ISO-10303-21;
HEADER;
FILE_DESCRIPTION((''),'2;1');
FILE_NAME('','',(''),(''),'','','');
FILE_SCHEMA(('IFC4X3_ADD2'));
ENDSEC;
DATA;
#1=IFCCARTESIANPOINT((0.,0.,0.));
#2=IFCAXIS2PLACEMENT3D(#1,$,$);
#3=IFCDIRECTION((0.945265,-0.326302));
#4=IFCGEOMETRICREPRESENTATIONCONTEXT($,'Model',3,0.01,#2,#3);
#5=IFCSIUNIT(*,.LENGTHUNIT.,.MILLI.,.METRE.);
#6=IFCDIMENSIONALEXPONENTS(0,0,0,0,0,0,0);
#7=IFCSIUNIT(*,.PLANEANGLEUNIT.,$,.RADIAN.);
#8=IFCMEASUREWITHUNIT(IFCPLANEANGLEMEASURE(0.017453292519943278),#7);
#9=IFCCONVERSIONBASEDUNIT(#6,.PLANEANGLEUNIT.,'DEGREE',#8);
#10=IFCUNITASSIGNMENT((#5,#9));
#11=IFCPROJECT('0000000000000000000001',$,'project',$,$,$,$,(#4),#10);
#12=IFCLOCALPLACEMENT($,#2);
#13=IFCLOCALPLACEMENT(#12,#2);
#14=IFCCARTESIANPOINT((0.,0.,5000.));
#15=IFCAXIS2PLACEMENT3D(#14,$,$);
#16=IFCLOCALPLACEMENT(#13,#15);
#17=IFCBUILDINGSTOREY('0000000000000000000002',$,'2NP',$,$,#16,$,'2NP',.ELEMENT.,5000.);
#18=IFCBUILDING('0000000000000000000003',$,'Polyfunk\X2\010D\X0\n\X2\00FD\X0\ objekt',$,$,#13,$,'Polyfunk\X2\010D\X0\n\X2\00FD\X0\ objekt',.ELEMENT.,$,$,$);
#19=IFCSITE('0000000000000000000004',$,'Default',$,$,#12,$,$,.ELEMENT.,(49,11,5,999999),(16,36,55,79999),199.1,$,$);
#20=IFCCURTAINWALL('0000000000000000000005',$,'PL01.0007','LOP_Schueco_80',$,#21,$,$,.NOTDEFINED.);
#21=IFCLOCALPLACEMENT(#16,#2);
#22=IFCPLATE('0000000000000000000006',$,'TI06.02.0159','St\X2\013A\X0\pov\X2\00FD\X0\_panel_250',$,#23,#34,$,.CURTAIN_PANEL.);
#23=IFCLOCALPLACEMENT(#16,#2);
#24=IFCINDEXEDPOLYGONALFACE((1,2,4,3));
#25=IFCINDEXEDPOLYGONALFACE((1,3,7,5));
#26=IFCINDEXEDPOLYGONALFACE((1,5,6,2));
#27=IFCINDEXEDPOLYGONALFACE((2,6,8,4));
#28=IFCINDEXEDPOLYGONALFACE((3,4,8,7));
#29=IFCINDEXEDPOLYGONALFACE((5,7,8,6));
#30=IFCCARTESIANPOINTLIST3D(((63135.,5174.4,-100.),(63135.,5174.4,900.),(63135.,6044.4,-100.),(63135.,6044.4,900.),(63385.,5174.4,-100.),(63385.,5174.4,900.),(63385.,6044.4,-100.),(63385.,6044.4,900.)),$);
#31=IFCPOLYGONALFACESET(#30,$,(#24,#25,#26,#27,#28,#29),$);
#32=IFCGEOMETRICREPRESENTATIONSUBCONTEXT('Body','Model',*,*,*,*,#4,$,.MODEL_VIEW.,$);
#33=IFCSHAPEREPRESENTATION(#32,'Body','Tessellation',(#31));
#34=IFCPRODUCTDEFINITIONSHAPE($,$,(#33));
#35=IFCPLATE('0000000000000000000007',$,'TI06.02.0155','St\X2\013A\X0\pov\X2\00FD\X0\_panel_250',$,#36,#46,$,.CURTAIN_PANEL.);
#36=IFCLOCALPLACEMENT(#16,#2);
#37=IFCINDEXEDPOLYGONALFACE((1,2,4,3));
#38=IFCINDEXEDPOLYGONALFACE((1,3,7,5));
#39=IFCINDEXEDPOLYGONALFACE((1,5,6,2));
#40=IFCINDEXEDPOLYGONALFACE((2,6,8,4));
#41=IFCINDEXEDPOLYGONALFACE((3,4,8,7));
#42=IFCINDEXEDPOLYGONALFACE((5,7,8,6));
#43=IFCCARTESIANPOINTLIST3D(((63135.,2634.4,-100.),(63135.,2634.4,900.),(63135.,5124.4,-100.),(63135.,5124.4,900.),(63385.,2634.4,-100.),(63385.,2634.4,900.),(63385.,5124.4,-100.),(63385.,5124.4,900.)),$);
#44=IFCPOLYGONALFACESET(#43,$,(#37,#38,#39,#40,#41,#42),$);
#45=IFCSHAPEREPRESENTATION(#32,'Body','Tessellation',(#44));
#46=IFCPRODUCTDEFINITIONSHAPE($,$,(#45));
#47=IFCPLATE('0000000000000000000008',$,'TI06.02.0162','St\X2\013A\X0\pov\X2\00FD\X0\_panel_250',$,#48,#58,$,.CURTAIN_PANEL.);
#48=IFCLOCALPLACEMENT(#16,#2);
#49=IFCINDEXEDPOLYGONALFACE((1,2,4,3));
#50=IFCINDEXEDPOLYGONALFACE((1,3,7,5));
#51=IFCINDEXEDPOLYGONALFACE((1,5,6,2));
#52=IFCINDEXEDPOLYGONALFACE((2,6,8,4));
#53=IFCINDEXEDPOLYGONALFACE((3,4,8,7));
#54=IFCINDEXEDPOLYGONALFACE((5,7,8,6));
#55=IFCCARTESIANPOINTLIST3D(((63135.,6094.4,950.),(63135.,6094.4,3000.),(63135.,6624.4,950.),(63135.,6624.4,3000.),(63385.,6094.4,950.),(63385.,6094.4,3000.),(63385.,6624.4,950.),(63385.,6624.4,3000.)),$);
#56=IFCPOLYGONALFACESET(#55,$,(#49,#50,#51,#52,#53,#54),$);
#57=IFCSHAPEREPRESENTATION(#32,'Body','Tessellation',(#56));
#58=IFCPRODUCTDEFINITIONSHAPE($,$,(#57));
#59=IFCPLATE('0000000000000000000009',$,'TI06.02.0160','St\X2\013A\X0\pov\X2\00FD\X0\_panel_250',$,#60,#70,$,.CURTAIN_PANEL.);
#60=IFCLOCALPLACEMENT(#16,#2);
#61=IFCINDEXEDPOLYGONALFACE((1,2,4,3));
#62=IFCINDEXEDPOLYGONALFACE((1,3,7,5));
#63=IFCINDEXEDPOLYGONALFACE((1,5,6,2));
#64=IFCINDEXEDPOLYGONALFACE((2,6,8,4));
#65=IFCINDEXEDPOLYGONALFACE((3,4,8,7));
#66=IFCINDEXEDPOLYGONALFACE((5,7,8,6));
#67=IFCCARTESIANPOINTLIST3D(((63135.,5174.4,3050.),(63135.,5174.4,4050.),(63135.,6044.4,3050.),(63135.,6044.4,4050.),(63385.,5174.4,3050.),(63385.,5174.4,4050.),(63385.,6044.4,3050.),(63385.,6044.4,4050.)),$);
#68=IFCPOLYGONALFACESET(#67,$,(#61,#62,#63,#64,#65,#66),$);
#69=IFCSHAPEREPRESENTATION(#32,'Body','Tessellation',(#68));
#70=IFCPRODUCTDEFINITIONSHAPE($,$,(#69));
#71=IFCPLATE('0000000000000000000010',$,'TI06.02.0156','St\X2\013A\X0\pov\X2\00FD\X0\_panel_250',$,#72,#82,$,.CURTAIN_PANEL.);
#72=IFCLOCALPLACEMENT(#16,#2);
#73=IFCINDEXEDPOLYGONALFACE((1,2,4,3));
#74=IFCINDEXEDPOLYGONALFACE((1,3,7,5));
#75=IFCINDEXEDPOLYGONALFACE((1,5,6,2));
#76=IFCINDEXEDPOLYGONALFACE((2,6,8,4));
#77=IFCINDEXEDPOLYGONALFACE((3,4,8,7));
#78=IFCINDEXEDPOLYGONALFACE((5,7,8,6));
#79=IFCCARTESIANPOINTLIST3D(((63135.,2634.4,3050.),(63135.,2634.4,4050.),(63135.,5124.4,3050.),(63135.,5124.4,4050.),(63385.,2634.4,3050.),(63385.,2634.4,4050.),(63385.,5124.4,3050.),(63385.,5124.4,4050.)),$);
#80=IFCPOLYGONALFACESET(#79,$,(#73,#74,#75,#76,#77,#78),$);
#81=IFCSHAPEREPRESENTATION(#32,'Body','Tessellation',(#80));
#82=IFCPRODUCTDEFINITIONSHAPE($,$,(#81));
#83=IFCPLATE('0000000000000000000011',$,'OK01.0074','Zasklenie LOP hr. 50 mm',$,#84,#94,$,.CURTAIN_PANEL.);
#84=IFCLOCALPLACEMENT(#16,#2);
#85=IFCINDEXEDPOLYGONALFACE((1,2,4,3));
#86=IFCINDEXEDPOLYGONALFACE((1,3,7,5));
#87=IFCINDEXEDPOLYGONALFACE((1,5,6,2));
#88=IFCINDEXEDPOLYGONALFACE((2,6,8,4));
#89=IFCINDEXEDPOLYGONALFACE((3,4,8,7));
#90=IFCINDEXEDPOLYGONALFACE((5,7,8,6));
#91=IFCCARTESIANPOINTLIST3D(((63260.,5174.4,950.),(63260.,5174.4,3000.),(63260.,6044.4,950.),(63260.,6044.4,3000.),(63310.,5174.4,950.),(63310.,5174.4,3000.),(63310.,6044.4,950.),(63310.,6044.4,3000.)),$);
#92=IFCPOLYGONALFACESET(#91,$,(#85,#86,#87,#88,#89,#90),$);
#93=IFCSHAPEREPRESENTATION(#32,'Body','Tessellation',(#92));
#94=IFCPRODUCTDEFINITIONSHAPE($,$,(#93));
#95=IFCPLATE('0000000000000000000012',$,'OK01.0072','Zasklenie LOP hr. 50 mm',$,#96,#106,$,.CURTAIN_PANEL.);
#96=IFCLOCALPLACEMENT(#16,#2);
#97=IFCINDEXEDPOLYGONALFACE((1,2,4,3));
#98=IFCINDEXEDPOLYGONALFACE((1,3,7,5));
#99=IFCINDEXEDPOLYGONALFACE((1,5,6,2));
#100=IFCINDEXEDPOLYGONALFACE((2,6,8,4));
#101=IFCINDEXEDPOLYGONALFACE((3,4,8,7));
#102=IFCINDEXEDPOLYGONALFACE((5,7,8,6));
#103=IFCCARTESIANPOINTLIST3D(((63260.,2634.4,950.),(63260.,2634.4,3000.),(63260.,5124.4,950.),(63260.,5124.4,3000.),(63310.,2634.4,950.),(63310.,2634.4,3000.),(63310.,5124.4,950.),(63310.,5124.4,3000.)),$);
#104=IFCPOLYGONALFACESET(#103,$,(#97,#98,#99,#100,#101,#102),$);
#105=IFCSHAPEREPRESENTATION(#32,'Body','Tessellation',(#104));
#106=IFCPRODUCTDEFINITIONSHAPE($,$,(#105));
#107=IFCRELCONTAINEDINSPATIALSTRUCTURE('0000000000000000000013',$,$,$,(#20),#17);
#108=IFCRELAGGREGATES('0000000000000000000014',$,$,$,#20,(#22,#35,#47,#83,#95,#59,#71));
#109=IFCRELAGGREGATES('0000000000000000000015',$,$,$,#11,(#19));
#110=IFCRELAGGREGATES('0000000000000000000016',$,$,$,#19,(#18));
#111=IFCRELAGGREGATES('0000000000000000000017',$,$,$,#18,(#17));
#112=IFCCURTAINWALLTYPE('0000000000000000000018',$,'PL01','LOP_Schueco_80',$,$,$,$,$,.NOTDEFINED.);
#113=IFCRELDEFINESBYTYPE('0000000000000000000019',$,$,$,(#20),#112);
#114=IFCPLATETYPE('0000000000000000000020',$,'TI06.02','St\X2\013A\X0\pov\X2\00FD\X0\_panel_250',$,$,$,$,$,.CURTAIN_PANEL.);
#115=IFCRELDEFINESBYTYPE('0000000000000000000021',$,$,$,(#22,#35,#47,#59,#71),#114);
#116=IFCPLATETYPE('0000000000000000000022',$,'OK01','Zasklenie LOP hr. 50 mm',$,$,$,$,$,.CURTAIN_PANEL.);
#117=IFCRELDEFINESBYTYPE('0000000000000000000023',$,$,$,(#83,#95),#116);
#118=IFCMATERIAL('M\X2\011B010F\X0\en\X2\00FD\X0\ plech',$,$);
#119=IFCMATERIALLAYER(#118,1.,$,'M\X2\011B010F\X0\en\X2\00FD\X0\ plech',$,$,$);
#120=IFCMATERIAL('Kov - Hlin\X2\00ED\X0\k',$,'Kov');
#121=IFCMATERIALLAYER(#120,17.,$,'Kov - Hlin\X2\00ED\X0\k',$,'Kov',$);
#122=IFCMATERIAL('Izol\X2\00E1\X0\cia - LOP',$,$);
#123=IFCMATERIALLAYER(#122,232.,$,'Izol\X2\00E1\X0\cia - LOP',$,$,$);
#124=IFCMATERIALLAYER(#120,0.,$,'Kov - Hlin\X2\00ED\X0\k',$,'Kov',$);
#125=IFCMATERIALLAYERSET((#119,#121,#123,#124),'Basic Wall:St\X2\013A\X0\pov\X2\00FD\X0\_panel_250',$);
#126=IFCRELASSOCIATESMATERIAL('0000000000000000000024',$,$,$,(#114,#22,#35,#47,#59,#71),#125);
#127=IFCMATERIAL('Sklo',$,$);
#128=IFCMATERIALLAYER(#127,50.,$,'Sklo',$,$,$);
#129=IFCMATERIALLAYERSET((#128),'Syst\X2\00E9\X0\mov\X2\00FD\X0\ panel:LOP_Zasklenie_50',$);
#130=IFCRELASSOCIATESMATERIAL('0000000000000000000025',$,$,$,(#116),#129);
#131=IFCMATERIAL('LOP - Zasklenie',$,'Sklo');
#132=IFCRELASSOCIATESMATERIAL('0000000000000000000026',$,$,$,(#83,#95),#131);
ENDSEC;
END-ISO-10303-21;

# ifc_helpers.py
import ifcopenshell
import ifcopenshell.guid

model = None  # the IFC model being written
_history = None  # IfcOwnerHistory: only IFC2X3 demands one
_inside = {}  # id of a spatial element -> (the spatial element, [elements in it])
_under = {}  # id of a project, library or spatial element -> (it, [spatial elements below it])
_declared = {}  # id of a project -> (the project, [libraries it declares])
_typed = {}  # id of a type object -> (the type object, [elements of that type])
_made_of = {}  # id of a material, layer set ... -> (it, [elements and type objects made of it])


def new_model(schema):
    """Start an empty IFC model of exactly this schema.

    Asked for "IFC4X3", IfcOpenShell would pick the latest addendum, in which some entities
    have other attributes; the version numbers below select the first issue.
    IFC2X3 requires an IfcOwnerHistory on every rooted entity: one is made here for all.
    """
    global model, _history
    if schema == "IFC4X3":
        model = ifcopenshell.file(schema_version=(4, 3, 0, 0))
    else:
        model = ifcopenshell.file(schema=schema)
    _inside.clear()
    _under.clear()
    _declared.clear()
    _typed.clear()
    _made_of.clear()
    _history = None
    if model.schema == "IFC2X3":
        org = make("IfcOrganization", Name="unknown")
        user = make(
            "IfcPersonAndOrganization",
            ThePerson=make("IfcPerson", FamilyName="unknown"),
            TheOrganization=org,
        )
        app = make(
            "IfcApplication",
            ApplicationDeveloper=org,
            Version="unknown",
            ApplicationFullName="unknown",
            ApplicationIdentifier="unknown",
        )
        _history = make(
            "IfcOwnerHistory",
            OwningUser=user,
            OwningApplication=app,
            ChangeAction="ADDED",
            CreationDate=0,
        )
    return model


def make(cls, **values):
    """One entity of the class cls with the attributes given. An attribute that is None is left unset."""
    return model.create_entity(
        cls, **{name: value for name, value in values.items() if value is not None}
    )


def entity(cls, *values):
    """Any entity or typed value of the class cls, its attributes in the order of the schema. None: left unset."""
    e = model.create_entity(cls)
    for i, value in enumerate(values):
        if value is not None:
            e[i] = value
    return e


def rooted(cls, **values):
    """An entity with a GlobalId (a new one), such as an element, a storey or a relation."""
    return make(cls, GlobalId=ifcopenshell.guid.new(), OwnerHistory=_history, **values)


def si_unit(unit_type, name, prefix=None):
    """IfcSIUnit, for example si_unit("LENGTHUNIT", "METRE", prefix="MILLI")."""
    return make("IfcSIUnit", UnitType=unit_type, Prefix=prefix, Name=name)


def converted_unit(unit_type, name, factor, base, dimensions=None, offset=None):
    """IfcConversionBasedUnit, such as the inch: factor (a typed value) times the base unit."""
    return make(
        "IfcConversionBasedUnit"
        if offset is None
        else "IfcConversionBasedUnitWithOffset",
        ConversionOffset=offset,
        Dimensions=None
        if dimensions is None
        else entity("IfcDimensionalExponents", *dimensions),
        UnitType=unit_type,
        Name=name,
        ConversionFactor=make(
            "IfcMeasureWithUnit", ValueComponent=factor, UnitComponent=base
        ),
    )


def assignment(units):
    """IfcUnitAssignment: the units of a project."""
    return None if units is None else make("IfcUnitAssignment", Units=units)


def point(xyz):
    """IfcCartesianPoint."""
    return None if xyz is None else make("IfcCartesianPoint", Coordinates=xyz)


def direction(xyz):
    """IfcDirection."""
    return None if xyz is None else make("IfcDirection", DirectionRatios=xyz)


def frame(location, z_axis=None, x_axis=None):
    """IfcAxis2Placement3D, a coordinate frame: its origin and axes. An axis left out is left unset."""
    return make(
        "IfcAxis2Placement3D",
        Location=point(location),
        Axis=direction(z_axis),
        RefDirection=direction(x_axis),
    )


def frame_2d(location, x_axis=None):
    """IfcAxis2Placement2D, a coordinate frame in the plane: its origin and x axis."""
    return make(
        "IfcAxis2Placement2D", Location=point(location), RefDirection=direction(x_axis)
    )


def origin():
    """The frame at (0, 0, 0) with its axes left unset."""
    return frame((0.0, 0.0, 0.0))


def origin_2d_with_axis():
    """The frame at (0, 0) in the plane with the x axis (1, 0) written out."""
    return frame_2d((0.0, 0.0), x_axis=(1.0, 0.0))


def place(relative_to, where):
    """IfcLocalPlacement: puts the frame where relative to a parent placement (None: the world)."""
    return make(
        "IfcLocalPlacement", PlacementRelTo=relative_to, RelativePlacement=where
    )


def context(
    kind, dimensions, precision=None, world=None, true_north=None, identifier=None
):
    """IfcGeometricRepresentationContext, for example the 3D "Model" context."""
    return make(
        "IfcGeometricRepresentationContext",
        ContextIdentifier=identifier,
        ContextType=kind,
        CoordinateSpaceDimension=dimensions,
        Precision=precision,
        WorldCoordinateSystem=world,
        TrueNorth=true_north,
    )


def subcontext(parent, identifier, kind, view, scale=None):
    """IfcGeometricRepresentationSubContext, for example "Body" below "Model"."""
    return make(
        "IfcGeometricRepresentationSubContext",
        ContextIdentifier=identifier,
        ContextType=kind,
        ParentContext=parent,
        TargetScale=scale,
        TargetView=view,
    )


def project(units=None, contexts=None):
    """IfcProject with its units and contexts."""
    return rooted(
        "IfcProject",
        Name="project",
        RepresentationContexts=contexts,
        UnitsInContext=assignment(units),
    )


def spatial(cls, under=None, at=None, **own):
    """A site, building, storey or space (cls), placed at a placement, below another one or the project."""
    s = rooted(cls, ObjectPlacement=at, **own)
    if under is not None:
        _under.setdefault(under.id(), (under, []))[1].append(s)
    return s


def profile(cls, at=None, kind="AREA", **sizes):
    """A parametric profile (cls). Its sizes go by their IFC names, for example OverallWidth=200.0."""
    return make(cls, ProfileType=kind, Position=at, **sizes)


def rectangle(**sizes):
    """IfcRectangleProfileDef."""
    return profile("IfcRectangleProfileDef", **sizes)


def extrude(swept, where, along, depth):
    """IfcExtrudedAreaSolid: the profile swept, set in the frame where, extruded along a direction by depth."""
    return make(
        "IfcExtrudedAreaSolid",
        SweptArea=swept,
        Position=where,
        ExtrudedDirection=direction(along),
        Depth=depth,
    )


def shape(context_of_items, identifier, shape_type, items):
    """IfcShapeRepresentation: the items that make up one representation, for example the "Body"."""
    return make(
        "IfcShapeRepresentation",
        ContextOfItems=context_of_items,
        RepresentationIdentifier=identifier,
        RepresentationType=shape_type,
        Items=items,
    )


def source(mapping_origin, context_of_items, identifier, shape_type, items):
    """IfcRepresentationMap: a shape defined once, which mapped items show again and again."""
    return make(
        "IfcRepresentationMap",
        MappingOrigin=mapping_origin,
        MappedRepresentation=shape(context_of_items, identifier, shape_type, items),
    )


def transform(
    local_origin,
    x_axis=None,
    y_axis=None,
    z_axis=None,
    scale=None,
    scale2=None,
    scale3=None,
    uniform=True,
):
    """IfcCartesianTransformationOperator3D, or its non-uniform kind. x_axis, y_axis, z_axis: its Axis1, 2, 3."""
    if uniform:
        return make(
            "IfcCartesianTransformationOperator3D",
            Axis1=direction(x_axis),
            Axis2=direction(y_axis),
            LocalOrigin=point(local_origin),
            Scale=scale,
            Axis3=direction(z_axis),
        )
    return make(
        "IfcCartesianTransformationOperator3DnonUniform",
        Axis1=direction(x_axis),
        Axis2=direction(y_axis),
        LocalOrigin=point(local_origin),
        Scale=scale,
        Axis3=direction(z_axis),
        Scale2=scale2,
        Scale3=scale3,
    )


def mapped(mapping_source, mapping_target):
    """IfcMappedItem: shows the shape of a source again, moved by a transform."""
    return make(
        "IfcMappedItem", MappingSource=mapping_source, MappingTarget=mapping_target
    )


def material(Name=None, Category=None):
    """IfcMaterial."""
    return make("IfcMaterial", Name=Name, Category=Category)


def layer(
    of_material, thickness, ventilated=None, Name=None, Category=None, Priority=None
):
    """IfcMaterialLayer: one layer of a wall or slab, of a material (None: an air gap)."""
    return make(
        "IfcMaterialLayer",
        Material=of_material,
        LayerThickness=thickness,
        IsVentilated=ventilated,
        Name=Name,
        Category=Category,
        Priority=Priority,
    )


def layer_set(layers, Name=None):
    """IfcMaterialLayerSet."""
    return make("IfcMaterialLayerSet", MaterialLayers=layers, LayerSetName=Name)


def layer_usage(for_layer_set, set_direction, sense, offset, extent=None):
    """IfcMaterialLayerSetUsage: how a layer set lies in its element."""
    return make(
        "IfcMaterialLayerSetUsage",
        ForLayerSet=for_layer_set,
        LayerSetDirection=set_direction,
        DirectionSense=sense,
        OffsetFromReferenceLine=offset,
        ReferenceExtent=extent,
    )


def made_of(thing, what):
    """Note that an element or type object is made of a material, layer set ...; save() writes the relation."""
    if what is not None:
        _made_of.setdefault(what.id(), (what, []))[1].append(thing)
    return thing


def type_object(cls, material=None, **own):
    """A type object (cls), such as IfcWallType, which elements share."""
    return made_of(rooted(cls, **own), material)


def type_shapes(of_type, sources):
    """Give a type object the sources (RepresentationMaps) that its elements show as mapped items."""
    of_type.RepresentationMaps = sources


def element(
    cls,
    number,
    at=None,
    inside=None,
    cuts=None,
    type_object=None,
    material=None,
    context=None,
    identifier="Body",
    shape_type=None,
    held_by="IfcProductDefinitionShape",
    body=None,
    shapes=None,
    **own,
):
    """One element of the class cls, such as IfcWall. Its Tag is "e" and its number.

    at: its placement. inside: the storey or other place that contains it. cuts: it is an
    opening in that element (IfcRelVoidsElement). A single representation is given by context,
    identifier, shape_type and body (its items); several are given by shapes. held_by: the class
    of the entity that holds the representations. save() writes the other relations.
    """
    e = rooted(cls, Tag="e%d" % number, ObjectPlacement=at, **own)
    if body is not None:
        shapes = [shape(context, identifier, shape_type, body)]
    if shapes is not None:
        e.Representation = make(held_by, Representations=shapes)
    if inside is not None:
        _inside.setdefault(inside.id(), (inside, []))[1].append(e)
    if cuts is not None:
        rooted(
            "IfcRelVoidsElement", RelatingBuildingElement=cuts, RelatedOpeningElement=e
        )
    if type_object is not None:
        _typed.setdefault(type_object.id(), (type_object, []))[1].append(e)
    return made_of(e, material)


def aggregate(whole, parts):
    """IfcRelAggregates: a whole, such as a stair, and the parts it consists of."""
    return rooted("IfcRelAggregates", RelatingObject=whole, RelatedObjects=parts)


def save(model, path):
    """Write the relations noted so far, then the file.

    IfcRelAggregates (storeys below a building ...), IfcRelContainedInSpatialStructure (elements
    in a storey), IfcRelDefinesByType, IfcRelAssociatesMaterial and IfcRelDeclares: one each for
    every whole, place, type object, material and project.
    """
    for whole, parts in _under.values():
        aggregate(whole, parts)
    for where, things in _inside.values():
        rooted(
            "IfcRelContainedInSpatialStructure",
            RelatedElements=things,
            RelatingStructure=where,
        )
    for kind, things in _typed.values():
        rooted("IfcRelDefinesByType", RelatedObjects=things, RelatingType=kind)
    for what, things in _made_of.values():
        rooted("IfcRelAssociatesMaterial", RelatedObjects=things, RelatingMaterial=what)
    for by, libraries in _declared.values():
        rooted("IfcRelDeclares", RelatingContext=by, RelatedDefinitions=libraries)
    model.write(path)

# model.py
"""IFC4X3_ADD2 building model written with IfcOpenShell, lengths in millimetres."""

from ifc_helpers import new_model, entity, si_unit, converted_unit, direction, frame, frame_2d, origin, origin_2d_with_axis, place, context, subcontext, project, spatial, rectangle, extrude, source, transform, mapped, material, layer, layer_set, layer_usage, type_object, type_shapes, element, aggregate, save


model = new_model("IFC4X3_ADD2")

# Units and contexts
model_context = context("Model", 3, precision=0.01, world=origin(), true_north=direction((0.945265, -0.326302)))
body_context = subcontext(model_context, "Body", "Model", "MODEL_VIEW")
ifc_project = project(units=[si_unit("LENGTHUNIT", "METRE", prefix="MILLI"), converted_unit("PLANEANGLEUNIT", "DEGREE", entity("IfcPlaneAngleMeasure", 0.017453292519943278), si_unit("PLANEANGLEUNIT", "RADIAN"), dimensions=[0, 0, 0, 0, 0, 0, 0])], contexts=[model_context])

# Site, building, storey
site_placement = place(None, origin())
site = spatial("IfcSite", under=ifc_project, at=site_placement, Name="Default", CompositionType="ELEMENT", RefLatitude=(49, 11, 5, 999999), RefLongitude=(16, 36, 55, 79999), RefElevation=199.1)
building_placement = place(site_placement, origin())
building = spatial("IfcBuilding", under=site, at=building_placement, Name="Polyfunkčný objekt", LongName="Polyfunkčný objekt", CompositionType="ELEMENT")
storey_placement = place(building_placement, frame((0.0, 0.0, 5000.0)))
storey = spatial("IfcBuildingStorey", under=building, at=storey_placement, Name="2NP", LongName="2NP", CompositionType="ELEMENT", Elevation=5000.0)

# Curtain wall, plates
curtain_wall_type = type_object("IfcCurtainWallType", Name="PL01", Description="LOP_Schueco_80", PredefinedType="NOTDEFINED")
curtain_wall_placement = place(storey_placement, frame((0.0, 0.0, -5000.0)))
curtain_wall = element("IfcCurtainWall", 1, at=curtain_wall_placement, inside=storey, type_object=curtain_wall_type, Name="PL01.0007", Description="LOP_Schueco_80", PredefinedType="NOTDEFINED")
ifc_material_1 = material(Name="Měďený plech")
ifc_layer_1 = layer(ifc_material_1, 1.0, Name="Měďený plech")
ifc_material_2 = material(Name="Kov - Hliník", Category="Kov")
ifc_layer_2 = layer(ifc_material_2, 17.0, Name="Kov - Hliník", Category="Kov")
ifc_material_3 = material(Name="Izolácia - LOP")
ifc_layer_3 = layer(ifc_material_3, 232.0, Name="Izolácia - LOP")
ifc_layer_4 = layer(ifc_material_2, 0.0, Name="Kov - Hliník", Category="Kov")
ifc_layer_set_1 = layer_set([ifc_layer_1, ifc_layer_2, ifc_layer_3, ifc_layer_4], Name="Basic Wall:Stĺpový_panel_250")
ifc_layer_usage_1 = layer_usage(ifc_layer_set_1, "AXIS2", "NEGATIVE", 125.0)
plate_type_1 = type_object("IfcPlateType", Name="TI06.02", Description="Stĺpový_panel_250", PredefinedType="CURTAIN_PANEL", material=ifc_layer_set_1)
plate_1_placement = place(storey_placement, frame((63260.0, 6044.4, -100.0), z_axis=(0.0, 0.0, 1.0), x_axis=(0.0, -1.0, 0.0)))
plate_1 = element("IfcPlate", 2, at=plate_1_placement, type_object=plate_type_1, material=ifc_layer_usage_1, Name="TI06.02.0159", Description="Stĺpový_panel_250", PredefinedType="CURTAIN_PANEL", context=body_context, shape_type="SweptSolid", body=[
    extrude(rectangle(XDim=250.0, YDim=870.0, at=frame_2d((0.0, 0.0), x_axis=(1.0, 0.0))), frame((435.0, 0.0, 0.0), z_axis=(0.0, 0.0, 1.0), x_axis=(0.0, 1.0, 0.0)), (0.0, 0.0, 1.0), 1000.0),
])
ifc_layer_usage_2 = layer_usage(ifc_layer_set_1, "AXIS2", "NEGATIVE", 125.0)
plate_2_placement = place(storey_placement, frame((63260.0, 5124.4, -100.0), z_axis=(0.0, 0.0, 1.0), x_axis=(0.0, -1.0, 0.0)))
plate_2 = element("IfcPlate", 3, at=plate_2_placement, type_object=plate_type_1, material=ifc_layer_usage_2, Name="TI06.02.0155", Description="Stĺpový_panel_250", PredefinedType="CURTAIN_PANEL", context=body_context, shape_type="SweptSolid", body=[
    extrude(rectangle(XDim=250.0, YDim=2490.0, at=origin_2d_with_axis()), frame((1245.0, 0.0, 0.0), z_axis=(0.0, 0.0, 1.0), x_axis=(0.0, 1.0, 0.0)), (0.0, 0.0, 1.0), 1000.0),
])
ifc_layer_usage_3 = layer_usage(ifc_layer_set_1, "AXIS2", "NEGATIVE", 125.0)
plate_3_placement = place(storey_placement, frame((63260.0, 6624.4, 950.0), z_axis=(0.0, 0.0, 1.0), x_axis=(0.0, -1.0, 0.0)))
plate_3 = element("IfcPlate", 4, at=plate_3_placement, type_object=plate_type_1, material=ifc_layer_usage_3, Name="TI06.02.0162", Description="Stĺpový_panel_250", PredefinedType="CURTAIN_PANEL", context=body_context, shape_type="SweptSolid", body=[
    extrude(rectangle(XDim=250.0, YDim=530.0, at=frame_2d((0.0, 0.0), x_axis=(1.0, 0.0))), frame((265.0, 0.0, 0.0), z_axis=(0.0, 0.0, 1.0), x_axis=(0.0, 1.0, 0.0)), (0.0, 0.0, 1.0), 2050.0),
])
ifc_layer_usage_4 = layer_usage(ifc_layer_set_1, "AXIS2", "NEGATIVE", 125.0)
plate_4_placement = place(storey_placement, frame((63260.0, 6044.4, 3050.0), z_axis=(0.0, 0.0, 1.0), x_axis=(0.0, -1.0, 0.0)))
plate_4 = element("IfcPlate", 5, at=plate_4_placement, type_object=plate_type_1, material=ifc_layer_usage_4, Name="TI06.02.0160", Description="Stĺpový_panel_250", PredefinedType="CURTAIN_PANEL", context=body_context, shape_type="SweptSolid", body=[
    extrude(rectangle(XDim=250.0, YDim=870.0, at=frame_2d((0.0, 0.0), x_axis=(1.0, 0.0))), frame((435.0, 0.0, 0.0), z_axis=(0.0, 0.0, 1.0), x_axis=(0.0, 1.0, 0.0)), (0.0, 0.0, 1.0), 1000.0),
])
ifc_layer_usage_5 = layer_usage(ifc_layer_set_1, "AXIS2", "NEGATIVE", 125.0)
plate_5_placement = place(storey_placement, frame((63260.0, 5124.4, 3050.0), z_axis=(0.0, 0.0, 1.0), x_axis=(0.0, -1.0, 0.0)))
plate_5 = element("IfcPlate", 6, at=plate_5_placement, type_object=plate_type_1, material=ifc_layer_usage_5, Name="TI06.02.0156", Description="Stĺpový_panel_250", PredefinedType="CURTAIN_PANEL", context=body_context, shape_type="SweptSolid", body=[
    extrude(rectangle(XDim=250.0, YDim=2490.0, at=frame_2d((0.0, 0.0), x_axis=(1.0, 0.0))), frame((1245.0, 0.0, 0.0), z_axis=(0.0, 0.0, 1.0), x_axis=(0.0, 1.0, 0.0)), (0.0, 0.0, 1.0), 1000.0),
])
ifc_material_4 = material(Name="LOP - Zasklenie", Category="Sklo")
ifc_material_5 = material(Name="Sklo")
ifc_layer_5 = layer(ifc_material_5, 50.0, Name="Sklo")
ifc_layer_set_2 = layer_set([ifc_layer_5], Name="Systémový panel:LOP_Zasklenie_50")
plate_type_2 = type_object("IfcPlateType", Name="OK01", Description="Zasklenie LOP hr. 50 mm", PredefinedType="CURTAIN_PANEL", material=ifc_layer_set_2)
shared_shape_1 = source(origin(), body_context, "Body", "SweptSolid", [
    extrude(rectangle(XDim=50.0, YDim=870.0, at=origin_2d_with_axis()), frame((0.0, 25.0, 0.0), z_axis=(0.0, 0.0, 1.0), x_axis=(0.0, 1.0, 0.0)), (0.0, 0.0, 1.0), 2050.0),
])
plate_6_placement = place(curtain_wall_placement, frame((63260.0, 5609.4, 5950.0), z_axis=(0.0, 0.0, 1.0), x_axis=(0.0, -1.0, 0.0)))
plate_6 = element("IfcPlate", 7, at=plate_6_placement, type_object=plate_type_2, material=ifc_material_4, Name="OK01.0074", Description="Zasklenie LOP hr. 50 mm", PredefinedType="CURTAIN_PANEL", context=body_context, shape_type="MappedRepresentation", body=[
    mapped(shared_shape_1, transform((0.0, 0.0, 0.0), scale=1.0)),
])
shared_shape_2 = source(origin(), body_context, "Body", "SweptSolid", [
    extrude(rectangle(XDim=50.0, YDim=2490.0, at=origin_2d_with_axis()), frame((0.0, 25.0, 0.0), z_axis=(0.0, 0.0, 1.0), x_axis=(0.0, 1.0, 0.0)), (0.0, 0.0, 1.0), 2050.0),
])
type_shapes(plate_type_2, [shared_shape_1, shared_shape_2])
plate_7_placement = place(curtain_wall_placement, frame((63260.0, 3879.4, 5950.0), z_axis=(0.0, 0.0, 1.0), x_axis=(0.0, -1.0, 0.0)))
plate_7 = element("IfcPlate", 8, at=plate_7_placement, type_object=plate_type_2, material=ifc_material_4, Name="OK01.0072", Description="Zasklenie LOP hr. 50 mm", PredefinedType="CURTAIN_PANEL", context=body_context, shape_type="MappedRepresentation", body=[
    mapped(shared_shape_2, transform((0.0, 0.0, 0.0), scale=1.0)),
])
aggregate(curtain_wall, [plate_1, plate_2, plate_3, plate_6, plate_7, plate_4, plate_5])

save(model, "model.ifc")
